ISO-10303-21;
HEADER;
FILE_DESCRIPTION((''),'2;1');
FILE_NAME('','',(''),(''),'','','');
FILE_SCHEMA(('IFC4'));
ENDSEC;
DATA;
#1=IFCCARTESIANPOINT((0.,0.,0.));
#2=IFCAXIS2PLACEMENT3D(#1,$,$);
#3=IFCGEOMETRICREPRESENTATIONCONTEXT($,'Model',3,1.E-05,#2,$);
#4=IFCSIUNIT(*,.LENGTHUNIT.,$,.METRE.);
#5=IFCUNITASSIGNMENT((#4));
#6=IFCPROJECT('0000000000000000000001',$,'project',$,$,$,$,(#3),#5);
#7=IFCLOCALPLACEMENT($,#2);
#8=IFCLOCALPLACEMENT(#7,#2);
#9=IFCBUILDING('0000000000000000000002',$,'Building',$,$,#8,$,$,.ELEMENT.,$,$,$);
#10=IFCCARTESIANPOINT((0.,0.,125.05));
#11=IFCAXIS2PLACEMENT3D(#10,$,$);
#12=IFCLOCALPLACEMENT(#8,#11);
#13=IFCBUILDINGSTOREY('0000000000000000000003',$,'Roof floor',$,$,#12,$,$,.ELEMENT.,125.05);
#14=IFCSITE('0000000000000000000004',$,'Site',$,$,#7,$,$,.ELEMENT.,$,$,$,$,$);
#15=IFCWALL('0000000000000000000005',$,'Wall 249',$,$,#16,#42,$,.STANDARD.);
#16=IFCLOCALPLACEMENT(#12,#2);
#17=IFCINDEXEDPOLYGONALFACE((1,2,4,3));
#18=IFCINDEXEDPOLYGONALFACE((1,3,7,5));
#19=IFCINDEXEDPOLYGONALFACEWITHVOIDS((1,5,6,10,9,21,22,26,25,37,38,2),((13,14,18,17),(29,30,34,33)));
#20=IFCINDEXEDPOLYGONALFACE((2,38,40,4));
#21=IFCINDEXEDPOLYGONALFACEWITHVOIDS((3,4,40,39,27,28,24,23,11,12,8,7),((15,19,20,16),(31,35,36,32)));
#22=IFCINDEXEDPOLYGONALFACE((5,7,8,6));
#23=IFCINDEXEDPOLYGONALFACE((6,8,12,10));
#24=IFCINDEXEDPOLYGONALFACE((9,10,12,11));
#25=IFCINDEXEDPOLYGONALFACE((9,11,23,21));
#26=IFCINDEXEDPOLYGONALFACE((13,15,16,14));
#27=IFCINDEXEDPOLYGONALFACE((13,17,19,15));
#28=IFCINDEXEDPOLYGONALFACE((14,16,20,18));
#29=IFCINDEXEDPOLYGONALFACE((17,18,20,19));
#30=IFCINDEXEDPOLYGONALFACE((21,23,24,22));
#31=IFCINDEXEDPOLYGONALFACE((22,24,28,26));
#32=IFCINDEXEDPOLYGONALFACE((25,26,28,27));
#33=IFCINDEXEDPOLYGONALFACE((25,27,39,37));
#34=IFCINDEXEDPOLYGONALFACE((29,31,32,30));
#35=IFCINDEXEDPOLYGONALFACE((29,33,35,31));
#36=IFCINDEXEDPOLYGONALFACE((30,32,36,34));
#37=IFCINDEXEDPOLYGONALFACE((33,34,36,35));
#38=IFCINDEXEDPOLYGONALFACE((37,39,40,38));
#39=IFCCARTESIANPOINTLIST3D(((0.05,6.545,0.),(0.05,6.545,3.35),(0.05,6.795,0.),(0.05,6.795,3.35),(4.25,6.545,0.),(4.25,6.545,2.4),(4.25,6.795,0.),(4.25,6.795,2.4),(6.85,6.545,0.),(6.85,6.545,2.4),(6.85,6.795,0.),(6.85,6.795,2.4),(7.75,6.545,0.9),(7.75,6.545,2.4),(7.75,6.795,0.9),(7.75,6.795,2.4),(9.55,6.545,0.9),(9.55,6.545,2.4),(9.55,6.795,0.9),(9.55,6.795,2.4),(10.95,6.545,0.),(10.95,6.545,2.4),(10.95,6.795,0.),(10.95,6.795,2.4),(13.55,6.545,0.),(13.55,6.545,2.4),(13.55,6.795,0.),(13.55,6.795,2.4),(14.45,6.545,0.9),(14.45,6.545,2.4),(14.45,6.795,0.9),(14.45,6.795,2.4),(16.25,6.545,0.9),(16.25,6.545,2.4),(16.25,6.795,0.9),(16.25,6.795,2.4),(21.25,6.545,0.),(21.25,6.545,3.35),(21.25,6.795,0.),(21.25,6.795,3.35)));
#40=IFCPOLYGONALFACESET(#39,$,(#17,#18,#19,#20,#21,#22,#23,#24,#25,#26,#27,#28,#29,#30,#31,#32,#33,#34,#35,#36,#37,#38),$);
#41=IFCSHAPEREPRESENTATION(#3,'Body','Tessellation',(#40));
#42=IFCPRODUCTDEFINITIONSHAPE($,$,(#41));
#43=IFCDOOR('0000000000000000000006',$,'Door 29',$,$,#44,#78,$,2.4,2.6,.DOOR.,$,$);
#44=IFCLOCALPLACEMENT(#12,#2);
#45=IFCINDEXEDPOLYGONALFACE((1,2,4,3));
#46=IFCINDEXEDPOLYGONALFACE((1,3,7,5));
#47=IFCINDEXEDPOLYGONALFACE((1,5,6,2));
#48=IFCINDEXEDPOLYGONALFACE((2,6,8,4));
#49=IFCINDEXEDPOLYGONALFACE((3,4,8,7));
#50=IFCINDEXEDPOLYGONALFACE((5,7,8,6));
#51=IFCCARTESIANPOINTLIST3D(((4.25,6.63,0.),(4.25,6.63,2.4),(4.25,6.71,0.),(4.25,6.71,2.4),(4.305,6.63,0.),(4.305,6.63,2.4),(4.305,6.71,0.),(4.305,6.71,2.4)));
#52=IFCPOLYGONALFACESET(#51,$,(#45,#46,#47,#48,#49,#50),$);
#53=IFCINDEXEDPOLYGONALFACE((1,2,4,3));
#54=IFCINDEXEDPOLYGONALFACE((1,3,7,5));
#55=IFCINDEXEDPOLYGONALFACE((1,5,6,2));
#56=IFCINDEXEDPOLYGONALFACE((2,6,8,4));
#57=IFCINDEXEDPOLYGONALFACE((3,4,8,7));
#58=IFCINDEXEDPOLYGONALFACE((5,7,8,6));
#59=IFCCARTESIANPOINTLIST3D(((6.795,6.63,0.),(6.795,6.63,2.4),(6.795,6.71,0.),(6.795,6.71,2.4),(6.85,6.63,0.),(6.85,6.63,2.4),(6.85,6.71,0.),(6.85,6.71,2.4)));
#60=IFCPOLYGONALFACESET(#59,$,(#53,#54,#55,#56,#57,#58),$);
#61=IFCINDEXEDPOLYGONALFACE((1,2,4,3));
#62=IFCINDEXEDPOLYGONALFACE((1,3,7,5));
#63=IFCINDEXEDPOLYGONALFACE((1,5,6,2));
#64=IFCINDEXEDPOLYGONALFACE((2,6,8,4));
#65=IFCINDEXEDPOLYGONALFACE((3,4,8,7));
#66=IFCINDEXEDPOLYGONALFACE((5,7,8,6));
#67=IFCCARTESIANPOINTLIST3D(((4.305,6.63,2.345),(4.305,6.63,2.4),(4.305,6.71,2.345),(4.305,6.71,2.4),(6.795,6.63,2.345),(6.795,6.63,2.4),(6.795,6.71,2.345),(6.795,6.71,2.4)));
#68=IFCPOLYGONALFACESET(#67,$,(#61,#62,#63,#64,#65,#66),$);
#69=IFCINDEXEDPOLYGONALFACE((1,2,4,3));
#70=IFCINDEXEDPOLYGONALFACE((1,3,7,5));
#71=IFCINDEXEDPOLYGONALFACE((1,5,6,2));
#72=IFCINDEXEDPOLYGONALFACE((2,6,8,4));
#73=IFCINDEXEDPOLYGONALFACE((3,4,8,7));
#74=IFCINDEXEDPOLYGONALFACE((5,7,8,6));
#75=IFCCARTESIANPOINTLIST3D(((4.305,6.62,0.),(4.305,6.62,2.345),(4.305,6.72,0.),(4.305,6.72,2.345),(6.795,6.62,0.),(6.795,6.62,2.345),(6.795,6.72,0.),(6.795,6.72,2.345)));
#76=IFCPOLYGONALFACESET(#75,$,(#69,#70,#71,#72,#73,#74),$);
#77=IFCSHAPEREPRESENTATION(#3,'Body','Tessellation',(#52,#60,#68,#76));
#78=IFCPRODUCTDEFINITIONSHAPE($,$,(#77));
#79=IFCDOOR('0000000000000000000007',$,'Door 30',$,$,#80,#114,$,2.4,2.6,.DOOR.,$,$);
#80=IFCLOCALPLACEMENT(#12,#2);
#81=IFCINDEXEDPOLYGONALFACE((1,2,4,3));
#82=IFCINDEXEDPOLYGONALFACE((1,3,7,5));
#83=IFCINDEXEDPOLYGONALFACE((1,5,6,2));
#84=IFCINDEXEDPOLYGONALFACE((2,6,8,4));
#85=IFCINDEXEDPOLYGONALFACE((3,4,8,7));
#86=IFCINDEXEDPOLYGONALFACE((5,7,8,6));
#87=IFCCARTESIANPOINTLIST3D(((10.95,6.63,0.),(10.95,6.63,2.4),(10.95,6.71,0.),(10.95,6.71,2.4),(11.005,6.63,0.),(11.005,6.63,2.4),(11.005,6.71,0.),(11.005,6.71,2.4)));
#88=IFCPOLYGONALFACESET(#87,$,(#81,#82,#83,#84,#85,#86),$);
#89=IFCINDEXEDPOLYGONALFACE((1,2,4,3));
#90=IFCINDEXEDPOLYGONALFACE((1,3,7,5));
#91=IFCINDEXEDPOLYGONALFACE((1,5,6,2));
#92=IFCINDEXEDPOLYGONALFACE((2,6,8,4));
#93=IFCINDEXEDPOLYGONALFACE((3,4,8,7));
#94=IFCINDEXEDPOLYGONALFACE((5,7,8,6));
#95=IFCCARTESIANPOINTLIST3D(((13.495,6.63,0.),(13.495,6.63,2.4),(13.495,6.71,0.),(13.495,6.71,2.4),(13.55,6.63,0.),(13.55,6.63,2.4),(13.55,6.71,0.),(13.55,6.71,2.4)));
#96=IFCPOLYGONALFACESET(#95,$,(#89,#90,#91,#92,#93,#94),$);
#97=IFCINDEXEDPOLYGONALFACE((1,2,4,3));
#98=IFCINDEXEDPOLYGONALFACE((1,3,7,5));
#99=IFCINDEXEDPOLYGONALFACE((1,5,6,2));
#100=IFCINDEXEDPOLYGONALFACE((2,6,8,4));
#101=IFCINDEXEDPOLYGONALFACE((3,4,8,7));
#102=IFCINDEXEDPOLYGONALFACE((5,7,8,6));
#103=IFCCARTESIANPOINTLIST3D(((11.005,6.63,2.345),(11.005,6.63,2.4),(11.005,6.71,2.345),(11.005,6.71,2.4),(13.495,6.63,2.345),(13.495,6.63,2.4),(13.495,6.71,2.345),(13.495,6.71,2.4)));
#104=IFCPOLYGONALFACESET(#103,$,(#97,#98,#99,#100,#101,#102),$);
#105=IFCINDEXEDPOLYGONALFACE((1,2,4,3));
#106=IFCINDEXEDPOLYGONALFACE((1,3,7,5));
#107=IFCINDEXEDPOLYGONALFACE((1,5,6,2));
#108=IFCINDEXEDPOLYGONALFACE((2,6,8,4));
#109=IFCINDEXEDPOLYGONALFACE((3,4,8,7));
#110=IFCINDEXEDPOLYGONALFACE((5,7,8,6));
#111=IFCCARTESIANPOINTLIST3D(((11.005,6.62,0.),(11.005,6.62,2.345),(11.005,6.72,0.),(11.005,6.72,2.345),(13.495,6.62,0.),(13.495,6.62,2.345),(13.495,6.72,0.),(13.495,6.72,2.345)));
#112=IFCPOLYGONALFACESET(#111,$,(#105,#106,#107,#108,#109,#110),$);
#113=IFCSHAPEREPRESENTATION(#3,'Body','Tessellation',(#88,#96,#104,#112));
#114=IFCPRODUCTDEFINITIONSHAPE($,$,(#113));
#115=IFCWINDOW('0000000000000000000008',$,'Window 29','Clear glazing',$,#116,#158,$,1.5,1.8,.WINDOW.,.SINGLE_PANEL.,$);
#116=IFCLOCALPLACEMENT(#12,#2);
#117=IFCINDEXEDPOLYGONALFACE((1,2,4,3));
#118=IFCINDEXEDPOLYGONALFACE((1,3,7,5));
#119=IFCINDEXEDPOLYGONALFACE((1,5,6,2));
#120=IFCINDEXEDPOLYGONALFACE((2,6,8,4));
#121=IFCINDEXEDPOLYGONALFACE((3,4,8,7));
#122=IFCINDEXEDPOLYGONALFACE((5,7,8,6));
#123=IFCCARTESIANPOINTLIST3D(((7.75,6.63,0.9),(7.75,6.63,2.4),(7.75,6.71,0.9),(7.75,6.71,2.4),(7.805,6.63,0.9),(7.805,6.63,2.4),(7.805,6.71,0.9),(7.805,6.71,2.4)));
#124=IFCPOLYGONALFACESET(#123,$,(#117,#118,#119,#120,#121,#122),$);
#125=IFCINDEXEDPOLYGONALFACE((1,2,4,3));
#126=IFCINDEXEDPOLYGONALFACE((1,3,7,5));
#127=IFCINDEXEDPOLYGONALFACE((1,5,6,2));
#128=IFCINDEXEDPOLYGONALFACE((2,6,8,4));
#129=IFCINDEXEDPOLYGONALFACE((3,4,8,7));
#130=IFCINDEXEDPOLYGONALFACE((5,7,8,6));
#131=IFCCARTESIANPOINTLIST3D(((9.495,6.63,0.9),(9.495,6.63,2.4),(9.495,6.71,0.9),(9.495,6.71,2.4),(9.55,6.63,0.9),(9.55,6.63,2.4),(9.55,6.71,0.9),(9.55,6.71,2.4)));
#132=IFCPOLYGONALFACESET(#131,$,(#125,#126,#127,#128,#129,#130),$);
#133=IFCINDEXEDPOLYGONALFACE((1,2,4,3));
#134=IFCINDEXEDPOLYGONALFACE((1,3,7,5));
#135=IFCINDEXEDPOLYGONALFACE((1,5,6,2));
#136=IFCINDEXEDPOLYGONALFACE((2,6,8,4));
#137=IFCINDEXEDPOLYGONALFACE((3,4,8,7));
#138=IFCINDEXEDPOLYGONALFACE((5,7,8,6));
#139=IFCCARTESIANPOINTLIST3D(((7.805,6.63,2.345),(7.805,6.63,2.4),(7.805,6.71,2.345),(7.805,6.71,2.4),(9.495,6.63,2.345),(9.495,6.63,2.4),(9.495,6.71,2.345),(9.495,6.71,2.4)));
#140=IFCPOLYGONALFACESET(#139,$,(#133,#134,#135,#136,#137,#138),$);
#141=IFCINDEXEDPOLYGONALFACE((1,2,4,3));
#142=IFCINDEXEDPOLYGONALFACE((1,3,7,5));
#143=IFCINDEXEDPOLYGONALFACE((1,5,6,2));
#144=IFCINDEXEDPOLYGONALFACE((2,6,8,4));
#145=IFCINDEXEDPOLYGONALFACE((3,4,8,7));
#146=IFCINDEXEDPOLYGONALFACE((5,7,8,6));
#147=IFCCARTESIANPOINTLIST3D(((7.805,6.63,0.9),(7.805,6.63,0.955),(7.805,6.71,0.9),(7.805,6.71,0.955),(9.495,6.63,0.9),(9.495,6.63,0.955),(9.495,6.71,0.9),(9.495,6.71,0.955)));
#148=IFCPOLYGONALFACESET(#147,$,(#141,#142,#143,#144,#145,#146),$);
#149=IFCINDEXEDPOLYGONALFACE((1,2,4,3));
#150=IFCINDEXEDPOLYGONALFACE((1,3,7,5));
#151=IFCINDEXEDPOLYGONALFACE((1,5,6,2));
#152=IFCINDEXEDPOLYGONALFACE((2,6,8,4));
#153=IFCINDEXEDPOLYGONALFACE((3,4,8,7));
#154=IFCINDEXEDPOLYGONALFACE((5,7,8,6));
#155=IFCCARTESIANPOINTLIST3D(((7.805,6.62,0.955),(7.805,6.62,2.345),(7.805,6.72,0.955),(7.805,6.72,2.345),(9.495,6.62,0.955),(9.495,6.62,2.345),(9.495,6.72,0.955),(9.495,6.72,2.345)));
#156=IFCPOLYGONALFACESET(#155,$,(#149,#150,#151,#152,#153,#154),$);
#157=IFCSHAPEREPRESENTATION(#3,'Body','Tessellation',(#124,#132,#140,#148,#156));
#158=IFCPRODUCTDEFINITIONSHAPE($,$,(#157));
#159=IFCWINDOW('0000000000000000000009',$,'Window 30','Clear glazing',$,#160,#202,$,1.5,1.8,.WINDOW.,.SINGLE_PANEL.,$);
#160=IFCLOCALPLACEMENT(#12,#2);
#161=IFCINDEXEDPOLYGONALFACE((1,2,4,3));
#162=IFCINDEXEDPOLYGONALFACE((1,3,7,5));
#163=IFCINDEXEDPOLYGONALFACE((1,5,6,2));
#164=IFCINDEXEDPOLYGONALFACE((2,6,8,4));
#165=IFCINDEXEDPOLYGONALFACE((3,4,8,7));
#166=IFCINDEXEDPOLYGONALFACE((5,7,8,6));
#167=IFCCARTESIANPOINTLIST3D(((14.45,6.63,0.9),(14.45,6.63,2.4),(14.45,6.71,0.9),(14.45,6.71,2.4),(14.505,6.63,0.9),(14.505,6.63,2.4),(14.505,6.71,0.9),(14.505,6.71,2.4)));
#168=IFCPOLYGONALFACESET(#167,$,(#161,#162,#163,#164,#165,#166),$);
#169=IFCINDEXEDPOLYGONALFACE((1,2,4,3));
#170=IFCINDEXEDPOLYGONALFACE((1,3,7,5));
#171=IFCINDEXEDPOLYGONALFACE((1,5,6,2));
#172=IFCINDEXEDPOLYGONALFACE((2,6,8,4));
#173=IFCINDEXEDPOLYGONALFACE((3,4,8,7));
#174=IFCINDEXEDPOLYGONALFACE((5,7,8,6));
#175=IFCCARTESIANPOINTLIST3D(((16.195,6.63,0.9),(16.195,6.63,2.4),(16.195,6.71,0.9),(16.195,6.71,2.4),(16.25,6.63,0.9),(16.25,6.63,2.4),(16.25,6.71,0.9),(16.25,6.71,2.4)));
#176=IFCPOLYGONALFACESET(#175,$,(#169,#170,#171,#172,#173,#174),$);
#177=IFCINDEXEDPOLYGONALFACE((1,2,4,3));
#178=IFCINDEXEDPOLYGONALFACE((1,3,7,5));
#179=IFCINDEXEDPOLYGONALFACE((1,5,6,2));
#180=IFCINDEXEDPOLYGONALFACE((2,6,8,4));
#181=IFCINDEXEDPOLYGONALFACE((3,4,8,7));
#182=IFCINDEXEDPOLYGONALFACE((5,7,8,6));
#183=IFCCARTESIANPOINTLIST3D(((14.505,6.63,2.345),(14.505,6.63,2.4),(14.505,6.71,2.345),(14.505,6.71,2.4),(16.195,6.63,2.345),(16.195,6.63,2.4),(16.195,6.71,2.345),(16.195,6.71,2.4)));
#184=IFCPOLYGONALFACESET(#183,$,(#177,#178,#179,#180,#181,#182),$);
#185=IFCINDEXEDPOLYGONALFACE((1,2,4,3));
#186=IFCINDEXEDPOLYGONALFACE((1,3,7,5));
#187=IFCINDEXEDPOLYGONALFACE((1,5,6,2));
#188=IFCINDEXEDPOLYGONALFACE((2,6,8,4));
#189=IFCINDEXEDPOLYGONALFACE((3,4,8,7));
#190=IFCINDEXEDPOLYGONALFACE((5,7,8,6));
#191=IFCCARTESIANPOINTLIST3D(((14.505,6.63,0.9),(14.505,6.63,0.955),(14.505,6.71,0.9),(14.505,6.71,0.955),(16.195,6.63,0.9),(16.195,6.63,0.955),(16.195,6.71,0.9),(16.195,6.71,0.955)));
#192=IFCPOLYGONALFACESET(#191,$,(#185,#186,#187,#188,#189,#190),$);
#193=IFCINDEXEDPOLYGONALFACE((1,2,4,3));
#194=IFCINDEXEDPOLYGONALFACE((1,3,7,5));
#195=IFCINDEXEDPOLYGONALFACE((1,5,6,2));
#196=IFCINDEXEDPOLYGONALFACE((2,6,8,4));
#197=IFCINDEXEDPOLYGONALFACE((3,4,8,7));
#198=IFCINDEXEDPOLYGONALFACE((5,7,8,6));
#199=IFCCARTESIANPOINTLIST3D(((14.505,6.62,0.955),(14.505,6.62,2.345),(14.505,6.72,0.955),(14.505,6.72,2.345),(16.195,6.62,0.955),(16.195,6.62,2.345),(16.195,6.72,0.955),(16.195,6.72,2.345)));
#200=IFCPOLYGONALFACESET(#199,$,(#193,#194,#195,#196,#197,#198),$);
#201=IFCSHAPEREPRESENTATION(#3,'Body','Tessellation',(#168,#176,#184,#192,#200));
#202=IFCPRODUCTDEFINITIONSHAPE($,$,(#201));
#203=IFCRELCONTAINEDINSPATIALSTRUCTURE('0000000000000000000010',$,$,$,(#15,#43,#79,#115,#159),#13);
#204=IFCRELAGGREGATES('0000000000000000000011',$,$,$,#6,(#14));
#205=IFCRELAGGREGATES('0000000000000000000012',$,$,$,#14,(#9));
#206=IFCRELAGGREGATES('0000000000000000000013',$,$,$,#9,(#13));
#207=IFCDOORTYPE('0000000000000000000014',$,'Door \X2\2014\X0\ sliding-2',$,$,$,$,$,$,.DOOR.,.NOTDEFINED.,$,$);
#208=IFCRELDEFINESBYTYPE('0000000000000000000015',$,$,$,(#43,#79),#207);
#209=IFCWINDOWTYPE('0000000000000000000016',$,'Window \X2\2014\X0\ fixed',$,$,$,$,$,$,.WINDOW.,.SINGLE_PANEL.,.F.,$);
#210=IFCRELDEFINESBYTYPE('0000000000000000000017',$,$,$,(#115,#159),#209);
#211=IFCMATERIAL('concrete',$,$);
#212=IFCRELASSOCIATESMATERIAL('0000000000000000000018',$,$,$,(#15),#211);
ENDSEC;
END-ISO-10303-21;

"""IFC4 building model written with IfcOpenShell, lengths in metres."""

from ifc_helpers import new_model, si_unit, frame, frame_2d, origin, place, context, project, spatial, rectangle, extrude, material, type_object, element, fill, save


model = new_model("IFC4")

# Units and contexts
model_context = context("Model", 3, precision=1e-05, world=origin())
ifc_project = project(units=[si_unit("LENGTHUNIT", "METRE")], contexts=[model_context])

# Site, building, storey
site_placement = place(None, origin())
site = spatial("IfcSite", under=ifc_project, at=site_placement, Name="Site", CompositionType="ELEMENT")
building_placement = place(site_placement, origin())
building = spatial("IfcBuilding", under=site, at=building_placement, Name="Building", CompositionType="ELEMENT")
storey_placement = place(building_placement, frame((0.0, 0.0, 125.05)))
storey = spatial("IfcBuildingStorey", under=building, at=storey_placement, Name="Roof floor", CompositionType="ELEMENT", Elevation=125.05)

# Shared definitions
ifc_material = material(Name="concrete")

# Wall, openings, doors, windows
wall_1_placement = place(storey_placement, frame((0.05, 6.67, 0.0), z_axis=(0.0, 0.0, 1.0), x_axis=(1.0, 0.0, 0.0)))
wall_1 = element("IfcWall", 1, at=wall_1_placement, inside=storey, material=ifc_material, Name="Wall 249", PredefinedType="STANDARD", context=model_context, shape_type="SweptSolid", body=[
    extrude(rectangle(XDim=21.2, YDim=0.25, at=frame_2d((10.6, 0.0))), origin(), (0.0, 0.0, 1.0), 3.35),
])
opening_1_placement = place(storey_placement, frame((4.25, 6.67, 0.0), z_axis=(0.0, 0.0, 1.0), x_axis=(1.0, 0.0, 0.0)))
opening_1 = element("IfcOpeningElement", 2, at=opening_1_placement, cuts=wall_1, PredefinedType="OPENING", context=model_context, shape_type="SweptSolid", body=[
    extrude(rectangle(XDim=2.6, YDim=0.31, at=frame_2d((1.3, 0.0))), origin(), (0.0, 0.0, 1.0), 2.4),
])
opening_2_placement = place(storey_placement, frame((7.75, 6.67, 0.9), z_axis=(0.0, 0.0, 1.0), x_axis=(1.0, 0.0, 0.0)))
opening_2 = element("IfcOpeningElement", 3, at=opening_2_placement, cuts=wall_1, PredefinedType="OPENING", context=model_context, shape_type="SweptSolid", body=[
    extrude(rectangle(XDim=1.8, YDim=0.31, at=frame_2d((0.9, 0.0))), origin(), (0.0, 0.0, 1.0), 1.5),
])
opening_3_placement = place(storey_placement, frame((10.95, 6.67, 0.0), z_axis=(0.0, 0.0, 1.0), x_axis=(1.0, 0.0, 0.0)))
opening_3 = element("IfcOpeningElement", 4, at=opening_3_placement, cuts=wall_1, PredefinedType="OPENING", context=model_context, shape_type="SweptSolid", body=[
    extrude(rectangle(XDim=2.6, YDim=0.31, at=frame_2d((1.3, 0.0))), origin(), (0.0, 0.0, 1.0), 2.4),
])
opening_4_placement = place(storey_placement, frame((14.45, 6.67, 0.9), z_axis=(0.0, 0.0, 1.0), x_axis=(1.0, 0.0, 0.0)))
opening_4 = element("IfcOpeningElement", 5, at=opening_4_placement, cuts=wall_1, PredefinedType="OPENING", context=model_context, shape_type="SweptSolid", body=[
    extrude(rectangle(XDim=1.8, YDim=0.31, at=frame_2d((0.9, 0.0))), origin(), (0.0, 0.0, 1.0), 1.5),
])
door_type = type_object("IfcDoorType", Name="Door — sliding-2", PredefinedType="DOOR")
door_1_placement = place(storey_placement, frame((4.25, 6.67, 0.0), z_axis=(0.0, 0.0, 1.0), x_axis=(1.0, 0.0, 0.0)))
door_1 = element("IfcDoor", 6, at=door_1_placement, inside=storey, type_object=door_type, Name="Door 29", OverallHeight=2.4, OverallWidth=2.6, PredefinedType="DOOR", context=model_context, shape_type="SweptSolid", body=[
    extrude(rectangle(XDim=0.055, YDim=0.08, at=frame_2d((0.0275, 0.0))), origin(), (0.0, 0.0, 1.0), 2.4),
    extrude(rectangle(XDim=0.055, YDim=0.08, at=frame_2d((2.5725, 0.0))), origin(), (0.0, 0.0, 1.0), 2.4),
    extrude(rectangle(XDim=2.49, YDim=0.08, at=frame_2d((1.3, 0.0))), frame((0.0, 0.0, 2.345)), (0.0, 0.0, 1.0), 0.055),
    extrude(rectangle(XDim=2.49, YDim=0.1, at=frame_2d((1.3, 0.0))), origin(), (0.0, 0.0, 1.0), 2.345),
])
fill(opening_1, door_1)
door_2_placement = place(storey_placement, frame((10.95, 6.67, 0.0), z_axis=(0.0, 0.0, 1.0), x_axis=(1.0, 0.0, 0.0)))
door_2 = element("IfcDoor", 7, at=door_2_placement, inside=storey, type_object=door_type, Name="Door 30", OverallHeight=2.4, OverallWidth=2.6, PredefinedType="DOOR", context=model_context, shape_type="SweptSolid", body=[
    extrude(rectangle(XDim=0.055, YDim=0.08, at=frame_2d((0.0275, 0.0))), origin(), (0.0, 0.0, 1.0), 2.4),
    extrude(rectangle(XDim=0.055, YDim=0.08, at=frame_2d((2.5725, 0.0))), origin(), (0.0, 0.0, 1.0), 2.4),
    extrude(rectangle(XDim=2.49, YDim=0.08, at=frame_2d((1.3, 0.0))), frame((0.0, 0.0, 2.345)), (0.0, 0.0, 1.0), 0.055),
    extrude(rectangle(XDim=2.49, YDim=0.1, at=frame_2d((1.3, 0.0))), origin(), (0.0, 0.0, 1.0), 2.345),
])
fill(opening_3, door_2)
window_type = type_object("IfcWindowType", Name="Window — fixed", ParameterTakesPrecedence=False, PartitioningType="SINGLE_PANEL", PredefinedType="WINDOW")
window_1_placement = place(storey_placement, frame((7.75, 6.67, 0.9), z_axis=(0.0, 0.0, 1.0), x_axis=(1.0, 0.0, 0.0)))
window_1 = element("IfcWindow", 8, at=window_1_placement, inside=storey, type_object=window_type, Name="Window 29", Description="Clear glazing", OverallHeight=1.5, OverallWidth=1.8, PartitioningType="SINGLE_PANEL", PredefinedType="WINDOW", context=model_context, shape_type="SweptSolid", body=[
    extrude(rectangle(XDim=0.055, YDim=0.08, at=frame_2d((0.0275, 0.0))), origin(), (0.0, 0.0, 1.0), 1.5),
    extrude(rectangle(XDim=0.055, YDim=0.08, at=frame_2d((1.7725, 0.0))), origin(), (0.0, 0.0, 1.0), 1.5),
    extrude(rectangle(XDim=1.69, YDim=0.08, at=frame_2d((0.9, 0.0))), frame((0.0, 0.0, 1.445)), (0.0, 0.0, 1.0), 0.055),
    extrude(rectangle(XDim=1.69, YDim=0.08, at=frame_2d((0.9, 0.0))), origin(), (0.0, 0.0, 1.0), 0.055),
    extrude(rectangle(XDim=1.69, YDim=0.1, at=frame_2d((0.9, 0.0))), frame((0.0, 0.0, 0.055)), (0.0, 0.0, 1.0), 1.39),
])
fill(opening_2, window_1)
window_2_placement = place(storey_placement, frame((14.45, 6.67, 0.9), z_axis=(0.0, 0.0, 1.0), x_axis=(1.0, 0.0, 0.0)))
window_2 = element("IfcWindow", 9, at=window_2_placement, inside=storey, type_object=window_type, Name="Window 30", Description="Clear glazing", OverallHeight=1.5, OverallWidth=1.8, PartitioningType="SINGLE_PANEL", PredefinedType="WINDOW", context=model_context, shape_type="SweptSolid", body=[
    extrude(rectangle(XDim=0.055, YDim=0.08, at=frame_2d((0.0275, 0.0))), origin(), (0.0, 0.0, 1.0), 1.5),
    extrude(rectangle(XDim=0.055, YDim=0.08, at=frame_2d((1.7725, 0.0))), origin(), (0.0, 0.0, 1.0), 1.5),
    extrude(rectangle(XDim=1.69, YDim=0.08, at=frame_2d((0.9, 0.0))), frame((0.0, 0.0, 1.445)), (0.0, 0.0, 1.0), 0.055),
    extrude(rectangle(XDim=1.69, YDim=0.08, at=frame_2d((0.9, 0.0))), origin(), (0.0, 0.0, 1.0), 0.055),
    extrude(rectangle(XDim=1.69, YDim=0.1, at=frame_2d((0.9, 0.0))), frame((0.0, 0.0, 0.055)), (0.0, 0.0, 1.0), 1.39),
])
fill(opening_4, window_2)

save(model, "model.ifc")
